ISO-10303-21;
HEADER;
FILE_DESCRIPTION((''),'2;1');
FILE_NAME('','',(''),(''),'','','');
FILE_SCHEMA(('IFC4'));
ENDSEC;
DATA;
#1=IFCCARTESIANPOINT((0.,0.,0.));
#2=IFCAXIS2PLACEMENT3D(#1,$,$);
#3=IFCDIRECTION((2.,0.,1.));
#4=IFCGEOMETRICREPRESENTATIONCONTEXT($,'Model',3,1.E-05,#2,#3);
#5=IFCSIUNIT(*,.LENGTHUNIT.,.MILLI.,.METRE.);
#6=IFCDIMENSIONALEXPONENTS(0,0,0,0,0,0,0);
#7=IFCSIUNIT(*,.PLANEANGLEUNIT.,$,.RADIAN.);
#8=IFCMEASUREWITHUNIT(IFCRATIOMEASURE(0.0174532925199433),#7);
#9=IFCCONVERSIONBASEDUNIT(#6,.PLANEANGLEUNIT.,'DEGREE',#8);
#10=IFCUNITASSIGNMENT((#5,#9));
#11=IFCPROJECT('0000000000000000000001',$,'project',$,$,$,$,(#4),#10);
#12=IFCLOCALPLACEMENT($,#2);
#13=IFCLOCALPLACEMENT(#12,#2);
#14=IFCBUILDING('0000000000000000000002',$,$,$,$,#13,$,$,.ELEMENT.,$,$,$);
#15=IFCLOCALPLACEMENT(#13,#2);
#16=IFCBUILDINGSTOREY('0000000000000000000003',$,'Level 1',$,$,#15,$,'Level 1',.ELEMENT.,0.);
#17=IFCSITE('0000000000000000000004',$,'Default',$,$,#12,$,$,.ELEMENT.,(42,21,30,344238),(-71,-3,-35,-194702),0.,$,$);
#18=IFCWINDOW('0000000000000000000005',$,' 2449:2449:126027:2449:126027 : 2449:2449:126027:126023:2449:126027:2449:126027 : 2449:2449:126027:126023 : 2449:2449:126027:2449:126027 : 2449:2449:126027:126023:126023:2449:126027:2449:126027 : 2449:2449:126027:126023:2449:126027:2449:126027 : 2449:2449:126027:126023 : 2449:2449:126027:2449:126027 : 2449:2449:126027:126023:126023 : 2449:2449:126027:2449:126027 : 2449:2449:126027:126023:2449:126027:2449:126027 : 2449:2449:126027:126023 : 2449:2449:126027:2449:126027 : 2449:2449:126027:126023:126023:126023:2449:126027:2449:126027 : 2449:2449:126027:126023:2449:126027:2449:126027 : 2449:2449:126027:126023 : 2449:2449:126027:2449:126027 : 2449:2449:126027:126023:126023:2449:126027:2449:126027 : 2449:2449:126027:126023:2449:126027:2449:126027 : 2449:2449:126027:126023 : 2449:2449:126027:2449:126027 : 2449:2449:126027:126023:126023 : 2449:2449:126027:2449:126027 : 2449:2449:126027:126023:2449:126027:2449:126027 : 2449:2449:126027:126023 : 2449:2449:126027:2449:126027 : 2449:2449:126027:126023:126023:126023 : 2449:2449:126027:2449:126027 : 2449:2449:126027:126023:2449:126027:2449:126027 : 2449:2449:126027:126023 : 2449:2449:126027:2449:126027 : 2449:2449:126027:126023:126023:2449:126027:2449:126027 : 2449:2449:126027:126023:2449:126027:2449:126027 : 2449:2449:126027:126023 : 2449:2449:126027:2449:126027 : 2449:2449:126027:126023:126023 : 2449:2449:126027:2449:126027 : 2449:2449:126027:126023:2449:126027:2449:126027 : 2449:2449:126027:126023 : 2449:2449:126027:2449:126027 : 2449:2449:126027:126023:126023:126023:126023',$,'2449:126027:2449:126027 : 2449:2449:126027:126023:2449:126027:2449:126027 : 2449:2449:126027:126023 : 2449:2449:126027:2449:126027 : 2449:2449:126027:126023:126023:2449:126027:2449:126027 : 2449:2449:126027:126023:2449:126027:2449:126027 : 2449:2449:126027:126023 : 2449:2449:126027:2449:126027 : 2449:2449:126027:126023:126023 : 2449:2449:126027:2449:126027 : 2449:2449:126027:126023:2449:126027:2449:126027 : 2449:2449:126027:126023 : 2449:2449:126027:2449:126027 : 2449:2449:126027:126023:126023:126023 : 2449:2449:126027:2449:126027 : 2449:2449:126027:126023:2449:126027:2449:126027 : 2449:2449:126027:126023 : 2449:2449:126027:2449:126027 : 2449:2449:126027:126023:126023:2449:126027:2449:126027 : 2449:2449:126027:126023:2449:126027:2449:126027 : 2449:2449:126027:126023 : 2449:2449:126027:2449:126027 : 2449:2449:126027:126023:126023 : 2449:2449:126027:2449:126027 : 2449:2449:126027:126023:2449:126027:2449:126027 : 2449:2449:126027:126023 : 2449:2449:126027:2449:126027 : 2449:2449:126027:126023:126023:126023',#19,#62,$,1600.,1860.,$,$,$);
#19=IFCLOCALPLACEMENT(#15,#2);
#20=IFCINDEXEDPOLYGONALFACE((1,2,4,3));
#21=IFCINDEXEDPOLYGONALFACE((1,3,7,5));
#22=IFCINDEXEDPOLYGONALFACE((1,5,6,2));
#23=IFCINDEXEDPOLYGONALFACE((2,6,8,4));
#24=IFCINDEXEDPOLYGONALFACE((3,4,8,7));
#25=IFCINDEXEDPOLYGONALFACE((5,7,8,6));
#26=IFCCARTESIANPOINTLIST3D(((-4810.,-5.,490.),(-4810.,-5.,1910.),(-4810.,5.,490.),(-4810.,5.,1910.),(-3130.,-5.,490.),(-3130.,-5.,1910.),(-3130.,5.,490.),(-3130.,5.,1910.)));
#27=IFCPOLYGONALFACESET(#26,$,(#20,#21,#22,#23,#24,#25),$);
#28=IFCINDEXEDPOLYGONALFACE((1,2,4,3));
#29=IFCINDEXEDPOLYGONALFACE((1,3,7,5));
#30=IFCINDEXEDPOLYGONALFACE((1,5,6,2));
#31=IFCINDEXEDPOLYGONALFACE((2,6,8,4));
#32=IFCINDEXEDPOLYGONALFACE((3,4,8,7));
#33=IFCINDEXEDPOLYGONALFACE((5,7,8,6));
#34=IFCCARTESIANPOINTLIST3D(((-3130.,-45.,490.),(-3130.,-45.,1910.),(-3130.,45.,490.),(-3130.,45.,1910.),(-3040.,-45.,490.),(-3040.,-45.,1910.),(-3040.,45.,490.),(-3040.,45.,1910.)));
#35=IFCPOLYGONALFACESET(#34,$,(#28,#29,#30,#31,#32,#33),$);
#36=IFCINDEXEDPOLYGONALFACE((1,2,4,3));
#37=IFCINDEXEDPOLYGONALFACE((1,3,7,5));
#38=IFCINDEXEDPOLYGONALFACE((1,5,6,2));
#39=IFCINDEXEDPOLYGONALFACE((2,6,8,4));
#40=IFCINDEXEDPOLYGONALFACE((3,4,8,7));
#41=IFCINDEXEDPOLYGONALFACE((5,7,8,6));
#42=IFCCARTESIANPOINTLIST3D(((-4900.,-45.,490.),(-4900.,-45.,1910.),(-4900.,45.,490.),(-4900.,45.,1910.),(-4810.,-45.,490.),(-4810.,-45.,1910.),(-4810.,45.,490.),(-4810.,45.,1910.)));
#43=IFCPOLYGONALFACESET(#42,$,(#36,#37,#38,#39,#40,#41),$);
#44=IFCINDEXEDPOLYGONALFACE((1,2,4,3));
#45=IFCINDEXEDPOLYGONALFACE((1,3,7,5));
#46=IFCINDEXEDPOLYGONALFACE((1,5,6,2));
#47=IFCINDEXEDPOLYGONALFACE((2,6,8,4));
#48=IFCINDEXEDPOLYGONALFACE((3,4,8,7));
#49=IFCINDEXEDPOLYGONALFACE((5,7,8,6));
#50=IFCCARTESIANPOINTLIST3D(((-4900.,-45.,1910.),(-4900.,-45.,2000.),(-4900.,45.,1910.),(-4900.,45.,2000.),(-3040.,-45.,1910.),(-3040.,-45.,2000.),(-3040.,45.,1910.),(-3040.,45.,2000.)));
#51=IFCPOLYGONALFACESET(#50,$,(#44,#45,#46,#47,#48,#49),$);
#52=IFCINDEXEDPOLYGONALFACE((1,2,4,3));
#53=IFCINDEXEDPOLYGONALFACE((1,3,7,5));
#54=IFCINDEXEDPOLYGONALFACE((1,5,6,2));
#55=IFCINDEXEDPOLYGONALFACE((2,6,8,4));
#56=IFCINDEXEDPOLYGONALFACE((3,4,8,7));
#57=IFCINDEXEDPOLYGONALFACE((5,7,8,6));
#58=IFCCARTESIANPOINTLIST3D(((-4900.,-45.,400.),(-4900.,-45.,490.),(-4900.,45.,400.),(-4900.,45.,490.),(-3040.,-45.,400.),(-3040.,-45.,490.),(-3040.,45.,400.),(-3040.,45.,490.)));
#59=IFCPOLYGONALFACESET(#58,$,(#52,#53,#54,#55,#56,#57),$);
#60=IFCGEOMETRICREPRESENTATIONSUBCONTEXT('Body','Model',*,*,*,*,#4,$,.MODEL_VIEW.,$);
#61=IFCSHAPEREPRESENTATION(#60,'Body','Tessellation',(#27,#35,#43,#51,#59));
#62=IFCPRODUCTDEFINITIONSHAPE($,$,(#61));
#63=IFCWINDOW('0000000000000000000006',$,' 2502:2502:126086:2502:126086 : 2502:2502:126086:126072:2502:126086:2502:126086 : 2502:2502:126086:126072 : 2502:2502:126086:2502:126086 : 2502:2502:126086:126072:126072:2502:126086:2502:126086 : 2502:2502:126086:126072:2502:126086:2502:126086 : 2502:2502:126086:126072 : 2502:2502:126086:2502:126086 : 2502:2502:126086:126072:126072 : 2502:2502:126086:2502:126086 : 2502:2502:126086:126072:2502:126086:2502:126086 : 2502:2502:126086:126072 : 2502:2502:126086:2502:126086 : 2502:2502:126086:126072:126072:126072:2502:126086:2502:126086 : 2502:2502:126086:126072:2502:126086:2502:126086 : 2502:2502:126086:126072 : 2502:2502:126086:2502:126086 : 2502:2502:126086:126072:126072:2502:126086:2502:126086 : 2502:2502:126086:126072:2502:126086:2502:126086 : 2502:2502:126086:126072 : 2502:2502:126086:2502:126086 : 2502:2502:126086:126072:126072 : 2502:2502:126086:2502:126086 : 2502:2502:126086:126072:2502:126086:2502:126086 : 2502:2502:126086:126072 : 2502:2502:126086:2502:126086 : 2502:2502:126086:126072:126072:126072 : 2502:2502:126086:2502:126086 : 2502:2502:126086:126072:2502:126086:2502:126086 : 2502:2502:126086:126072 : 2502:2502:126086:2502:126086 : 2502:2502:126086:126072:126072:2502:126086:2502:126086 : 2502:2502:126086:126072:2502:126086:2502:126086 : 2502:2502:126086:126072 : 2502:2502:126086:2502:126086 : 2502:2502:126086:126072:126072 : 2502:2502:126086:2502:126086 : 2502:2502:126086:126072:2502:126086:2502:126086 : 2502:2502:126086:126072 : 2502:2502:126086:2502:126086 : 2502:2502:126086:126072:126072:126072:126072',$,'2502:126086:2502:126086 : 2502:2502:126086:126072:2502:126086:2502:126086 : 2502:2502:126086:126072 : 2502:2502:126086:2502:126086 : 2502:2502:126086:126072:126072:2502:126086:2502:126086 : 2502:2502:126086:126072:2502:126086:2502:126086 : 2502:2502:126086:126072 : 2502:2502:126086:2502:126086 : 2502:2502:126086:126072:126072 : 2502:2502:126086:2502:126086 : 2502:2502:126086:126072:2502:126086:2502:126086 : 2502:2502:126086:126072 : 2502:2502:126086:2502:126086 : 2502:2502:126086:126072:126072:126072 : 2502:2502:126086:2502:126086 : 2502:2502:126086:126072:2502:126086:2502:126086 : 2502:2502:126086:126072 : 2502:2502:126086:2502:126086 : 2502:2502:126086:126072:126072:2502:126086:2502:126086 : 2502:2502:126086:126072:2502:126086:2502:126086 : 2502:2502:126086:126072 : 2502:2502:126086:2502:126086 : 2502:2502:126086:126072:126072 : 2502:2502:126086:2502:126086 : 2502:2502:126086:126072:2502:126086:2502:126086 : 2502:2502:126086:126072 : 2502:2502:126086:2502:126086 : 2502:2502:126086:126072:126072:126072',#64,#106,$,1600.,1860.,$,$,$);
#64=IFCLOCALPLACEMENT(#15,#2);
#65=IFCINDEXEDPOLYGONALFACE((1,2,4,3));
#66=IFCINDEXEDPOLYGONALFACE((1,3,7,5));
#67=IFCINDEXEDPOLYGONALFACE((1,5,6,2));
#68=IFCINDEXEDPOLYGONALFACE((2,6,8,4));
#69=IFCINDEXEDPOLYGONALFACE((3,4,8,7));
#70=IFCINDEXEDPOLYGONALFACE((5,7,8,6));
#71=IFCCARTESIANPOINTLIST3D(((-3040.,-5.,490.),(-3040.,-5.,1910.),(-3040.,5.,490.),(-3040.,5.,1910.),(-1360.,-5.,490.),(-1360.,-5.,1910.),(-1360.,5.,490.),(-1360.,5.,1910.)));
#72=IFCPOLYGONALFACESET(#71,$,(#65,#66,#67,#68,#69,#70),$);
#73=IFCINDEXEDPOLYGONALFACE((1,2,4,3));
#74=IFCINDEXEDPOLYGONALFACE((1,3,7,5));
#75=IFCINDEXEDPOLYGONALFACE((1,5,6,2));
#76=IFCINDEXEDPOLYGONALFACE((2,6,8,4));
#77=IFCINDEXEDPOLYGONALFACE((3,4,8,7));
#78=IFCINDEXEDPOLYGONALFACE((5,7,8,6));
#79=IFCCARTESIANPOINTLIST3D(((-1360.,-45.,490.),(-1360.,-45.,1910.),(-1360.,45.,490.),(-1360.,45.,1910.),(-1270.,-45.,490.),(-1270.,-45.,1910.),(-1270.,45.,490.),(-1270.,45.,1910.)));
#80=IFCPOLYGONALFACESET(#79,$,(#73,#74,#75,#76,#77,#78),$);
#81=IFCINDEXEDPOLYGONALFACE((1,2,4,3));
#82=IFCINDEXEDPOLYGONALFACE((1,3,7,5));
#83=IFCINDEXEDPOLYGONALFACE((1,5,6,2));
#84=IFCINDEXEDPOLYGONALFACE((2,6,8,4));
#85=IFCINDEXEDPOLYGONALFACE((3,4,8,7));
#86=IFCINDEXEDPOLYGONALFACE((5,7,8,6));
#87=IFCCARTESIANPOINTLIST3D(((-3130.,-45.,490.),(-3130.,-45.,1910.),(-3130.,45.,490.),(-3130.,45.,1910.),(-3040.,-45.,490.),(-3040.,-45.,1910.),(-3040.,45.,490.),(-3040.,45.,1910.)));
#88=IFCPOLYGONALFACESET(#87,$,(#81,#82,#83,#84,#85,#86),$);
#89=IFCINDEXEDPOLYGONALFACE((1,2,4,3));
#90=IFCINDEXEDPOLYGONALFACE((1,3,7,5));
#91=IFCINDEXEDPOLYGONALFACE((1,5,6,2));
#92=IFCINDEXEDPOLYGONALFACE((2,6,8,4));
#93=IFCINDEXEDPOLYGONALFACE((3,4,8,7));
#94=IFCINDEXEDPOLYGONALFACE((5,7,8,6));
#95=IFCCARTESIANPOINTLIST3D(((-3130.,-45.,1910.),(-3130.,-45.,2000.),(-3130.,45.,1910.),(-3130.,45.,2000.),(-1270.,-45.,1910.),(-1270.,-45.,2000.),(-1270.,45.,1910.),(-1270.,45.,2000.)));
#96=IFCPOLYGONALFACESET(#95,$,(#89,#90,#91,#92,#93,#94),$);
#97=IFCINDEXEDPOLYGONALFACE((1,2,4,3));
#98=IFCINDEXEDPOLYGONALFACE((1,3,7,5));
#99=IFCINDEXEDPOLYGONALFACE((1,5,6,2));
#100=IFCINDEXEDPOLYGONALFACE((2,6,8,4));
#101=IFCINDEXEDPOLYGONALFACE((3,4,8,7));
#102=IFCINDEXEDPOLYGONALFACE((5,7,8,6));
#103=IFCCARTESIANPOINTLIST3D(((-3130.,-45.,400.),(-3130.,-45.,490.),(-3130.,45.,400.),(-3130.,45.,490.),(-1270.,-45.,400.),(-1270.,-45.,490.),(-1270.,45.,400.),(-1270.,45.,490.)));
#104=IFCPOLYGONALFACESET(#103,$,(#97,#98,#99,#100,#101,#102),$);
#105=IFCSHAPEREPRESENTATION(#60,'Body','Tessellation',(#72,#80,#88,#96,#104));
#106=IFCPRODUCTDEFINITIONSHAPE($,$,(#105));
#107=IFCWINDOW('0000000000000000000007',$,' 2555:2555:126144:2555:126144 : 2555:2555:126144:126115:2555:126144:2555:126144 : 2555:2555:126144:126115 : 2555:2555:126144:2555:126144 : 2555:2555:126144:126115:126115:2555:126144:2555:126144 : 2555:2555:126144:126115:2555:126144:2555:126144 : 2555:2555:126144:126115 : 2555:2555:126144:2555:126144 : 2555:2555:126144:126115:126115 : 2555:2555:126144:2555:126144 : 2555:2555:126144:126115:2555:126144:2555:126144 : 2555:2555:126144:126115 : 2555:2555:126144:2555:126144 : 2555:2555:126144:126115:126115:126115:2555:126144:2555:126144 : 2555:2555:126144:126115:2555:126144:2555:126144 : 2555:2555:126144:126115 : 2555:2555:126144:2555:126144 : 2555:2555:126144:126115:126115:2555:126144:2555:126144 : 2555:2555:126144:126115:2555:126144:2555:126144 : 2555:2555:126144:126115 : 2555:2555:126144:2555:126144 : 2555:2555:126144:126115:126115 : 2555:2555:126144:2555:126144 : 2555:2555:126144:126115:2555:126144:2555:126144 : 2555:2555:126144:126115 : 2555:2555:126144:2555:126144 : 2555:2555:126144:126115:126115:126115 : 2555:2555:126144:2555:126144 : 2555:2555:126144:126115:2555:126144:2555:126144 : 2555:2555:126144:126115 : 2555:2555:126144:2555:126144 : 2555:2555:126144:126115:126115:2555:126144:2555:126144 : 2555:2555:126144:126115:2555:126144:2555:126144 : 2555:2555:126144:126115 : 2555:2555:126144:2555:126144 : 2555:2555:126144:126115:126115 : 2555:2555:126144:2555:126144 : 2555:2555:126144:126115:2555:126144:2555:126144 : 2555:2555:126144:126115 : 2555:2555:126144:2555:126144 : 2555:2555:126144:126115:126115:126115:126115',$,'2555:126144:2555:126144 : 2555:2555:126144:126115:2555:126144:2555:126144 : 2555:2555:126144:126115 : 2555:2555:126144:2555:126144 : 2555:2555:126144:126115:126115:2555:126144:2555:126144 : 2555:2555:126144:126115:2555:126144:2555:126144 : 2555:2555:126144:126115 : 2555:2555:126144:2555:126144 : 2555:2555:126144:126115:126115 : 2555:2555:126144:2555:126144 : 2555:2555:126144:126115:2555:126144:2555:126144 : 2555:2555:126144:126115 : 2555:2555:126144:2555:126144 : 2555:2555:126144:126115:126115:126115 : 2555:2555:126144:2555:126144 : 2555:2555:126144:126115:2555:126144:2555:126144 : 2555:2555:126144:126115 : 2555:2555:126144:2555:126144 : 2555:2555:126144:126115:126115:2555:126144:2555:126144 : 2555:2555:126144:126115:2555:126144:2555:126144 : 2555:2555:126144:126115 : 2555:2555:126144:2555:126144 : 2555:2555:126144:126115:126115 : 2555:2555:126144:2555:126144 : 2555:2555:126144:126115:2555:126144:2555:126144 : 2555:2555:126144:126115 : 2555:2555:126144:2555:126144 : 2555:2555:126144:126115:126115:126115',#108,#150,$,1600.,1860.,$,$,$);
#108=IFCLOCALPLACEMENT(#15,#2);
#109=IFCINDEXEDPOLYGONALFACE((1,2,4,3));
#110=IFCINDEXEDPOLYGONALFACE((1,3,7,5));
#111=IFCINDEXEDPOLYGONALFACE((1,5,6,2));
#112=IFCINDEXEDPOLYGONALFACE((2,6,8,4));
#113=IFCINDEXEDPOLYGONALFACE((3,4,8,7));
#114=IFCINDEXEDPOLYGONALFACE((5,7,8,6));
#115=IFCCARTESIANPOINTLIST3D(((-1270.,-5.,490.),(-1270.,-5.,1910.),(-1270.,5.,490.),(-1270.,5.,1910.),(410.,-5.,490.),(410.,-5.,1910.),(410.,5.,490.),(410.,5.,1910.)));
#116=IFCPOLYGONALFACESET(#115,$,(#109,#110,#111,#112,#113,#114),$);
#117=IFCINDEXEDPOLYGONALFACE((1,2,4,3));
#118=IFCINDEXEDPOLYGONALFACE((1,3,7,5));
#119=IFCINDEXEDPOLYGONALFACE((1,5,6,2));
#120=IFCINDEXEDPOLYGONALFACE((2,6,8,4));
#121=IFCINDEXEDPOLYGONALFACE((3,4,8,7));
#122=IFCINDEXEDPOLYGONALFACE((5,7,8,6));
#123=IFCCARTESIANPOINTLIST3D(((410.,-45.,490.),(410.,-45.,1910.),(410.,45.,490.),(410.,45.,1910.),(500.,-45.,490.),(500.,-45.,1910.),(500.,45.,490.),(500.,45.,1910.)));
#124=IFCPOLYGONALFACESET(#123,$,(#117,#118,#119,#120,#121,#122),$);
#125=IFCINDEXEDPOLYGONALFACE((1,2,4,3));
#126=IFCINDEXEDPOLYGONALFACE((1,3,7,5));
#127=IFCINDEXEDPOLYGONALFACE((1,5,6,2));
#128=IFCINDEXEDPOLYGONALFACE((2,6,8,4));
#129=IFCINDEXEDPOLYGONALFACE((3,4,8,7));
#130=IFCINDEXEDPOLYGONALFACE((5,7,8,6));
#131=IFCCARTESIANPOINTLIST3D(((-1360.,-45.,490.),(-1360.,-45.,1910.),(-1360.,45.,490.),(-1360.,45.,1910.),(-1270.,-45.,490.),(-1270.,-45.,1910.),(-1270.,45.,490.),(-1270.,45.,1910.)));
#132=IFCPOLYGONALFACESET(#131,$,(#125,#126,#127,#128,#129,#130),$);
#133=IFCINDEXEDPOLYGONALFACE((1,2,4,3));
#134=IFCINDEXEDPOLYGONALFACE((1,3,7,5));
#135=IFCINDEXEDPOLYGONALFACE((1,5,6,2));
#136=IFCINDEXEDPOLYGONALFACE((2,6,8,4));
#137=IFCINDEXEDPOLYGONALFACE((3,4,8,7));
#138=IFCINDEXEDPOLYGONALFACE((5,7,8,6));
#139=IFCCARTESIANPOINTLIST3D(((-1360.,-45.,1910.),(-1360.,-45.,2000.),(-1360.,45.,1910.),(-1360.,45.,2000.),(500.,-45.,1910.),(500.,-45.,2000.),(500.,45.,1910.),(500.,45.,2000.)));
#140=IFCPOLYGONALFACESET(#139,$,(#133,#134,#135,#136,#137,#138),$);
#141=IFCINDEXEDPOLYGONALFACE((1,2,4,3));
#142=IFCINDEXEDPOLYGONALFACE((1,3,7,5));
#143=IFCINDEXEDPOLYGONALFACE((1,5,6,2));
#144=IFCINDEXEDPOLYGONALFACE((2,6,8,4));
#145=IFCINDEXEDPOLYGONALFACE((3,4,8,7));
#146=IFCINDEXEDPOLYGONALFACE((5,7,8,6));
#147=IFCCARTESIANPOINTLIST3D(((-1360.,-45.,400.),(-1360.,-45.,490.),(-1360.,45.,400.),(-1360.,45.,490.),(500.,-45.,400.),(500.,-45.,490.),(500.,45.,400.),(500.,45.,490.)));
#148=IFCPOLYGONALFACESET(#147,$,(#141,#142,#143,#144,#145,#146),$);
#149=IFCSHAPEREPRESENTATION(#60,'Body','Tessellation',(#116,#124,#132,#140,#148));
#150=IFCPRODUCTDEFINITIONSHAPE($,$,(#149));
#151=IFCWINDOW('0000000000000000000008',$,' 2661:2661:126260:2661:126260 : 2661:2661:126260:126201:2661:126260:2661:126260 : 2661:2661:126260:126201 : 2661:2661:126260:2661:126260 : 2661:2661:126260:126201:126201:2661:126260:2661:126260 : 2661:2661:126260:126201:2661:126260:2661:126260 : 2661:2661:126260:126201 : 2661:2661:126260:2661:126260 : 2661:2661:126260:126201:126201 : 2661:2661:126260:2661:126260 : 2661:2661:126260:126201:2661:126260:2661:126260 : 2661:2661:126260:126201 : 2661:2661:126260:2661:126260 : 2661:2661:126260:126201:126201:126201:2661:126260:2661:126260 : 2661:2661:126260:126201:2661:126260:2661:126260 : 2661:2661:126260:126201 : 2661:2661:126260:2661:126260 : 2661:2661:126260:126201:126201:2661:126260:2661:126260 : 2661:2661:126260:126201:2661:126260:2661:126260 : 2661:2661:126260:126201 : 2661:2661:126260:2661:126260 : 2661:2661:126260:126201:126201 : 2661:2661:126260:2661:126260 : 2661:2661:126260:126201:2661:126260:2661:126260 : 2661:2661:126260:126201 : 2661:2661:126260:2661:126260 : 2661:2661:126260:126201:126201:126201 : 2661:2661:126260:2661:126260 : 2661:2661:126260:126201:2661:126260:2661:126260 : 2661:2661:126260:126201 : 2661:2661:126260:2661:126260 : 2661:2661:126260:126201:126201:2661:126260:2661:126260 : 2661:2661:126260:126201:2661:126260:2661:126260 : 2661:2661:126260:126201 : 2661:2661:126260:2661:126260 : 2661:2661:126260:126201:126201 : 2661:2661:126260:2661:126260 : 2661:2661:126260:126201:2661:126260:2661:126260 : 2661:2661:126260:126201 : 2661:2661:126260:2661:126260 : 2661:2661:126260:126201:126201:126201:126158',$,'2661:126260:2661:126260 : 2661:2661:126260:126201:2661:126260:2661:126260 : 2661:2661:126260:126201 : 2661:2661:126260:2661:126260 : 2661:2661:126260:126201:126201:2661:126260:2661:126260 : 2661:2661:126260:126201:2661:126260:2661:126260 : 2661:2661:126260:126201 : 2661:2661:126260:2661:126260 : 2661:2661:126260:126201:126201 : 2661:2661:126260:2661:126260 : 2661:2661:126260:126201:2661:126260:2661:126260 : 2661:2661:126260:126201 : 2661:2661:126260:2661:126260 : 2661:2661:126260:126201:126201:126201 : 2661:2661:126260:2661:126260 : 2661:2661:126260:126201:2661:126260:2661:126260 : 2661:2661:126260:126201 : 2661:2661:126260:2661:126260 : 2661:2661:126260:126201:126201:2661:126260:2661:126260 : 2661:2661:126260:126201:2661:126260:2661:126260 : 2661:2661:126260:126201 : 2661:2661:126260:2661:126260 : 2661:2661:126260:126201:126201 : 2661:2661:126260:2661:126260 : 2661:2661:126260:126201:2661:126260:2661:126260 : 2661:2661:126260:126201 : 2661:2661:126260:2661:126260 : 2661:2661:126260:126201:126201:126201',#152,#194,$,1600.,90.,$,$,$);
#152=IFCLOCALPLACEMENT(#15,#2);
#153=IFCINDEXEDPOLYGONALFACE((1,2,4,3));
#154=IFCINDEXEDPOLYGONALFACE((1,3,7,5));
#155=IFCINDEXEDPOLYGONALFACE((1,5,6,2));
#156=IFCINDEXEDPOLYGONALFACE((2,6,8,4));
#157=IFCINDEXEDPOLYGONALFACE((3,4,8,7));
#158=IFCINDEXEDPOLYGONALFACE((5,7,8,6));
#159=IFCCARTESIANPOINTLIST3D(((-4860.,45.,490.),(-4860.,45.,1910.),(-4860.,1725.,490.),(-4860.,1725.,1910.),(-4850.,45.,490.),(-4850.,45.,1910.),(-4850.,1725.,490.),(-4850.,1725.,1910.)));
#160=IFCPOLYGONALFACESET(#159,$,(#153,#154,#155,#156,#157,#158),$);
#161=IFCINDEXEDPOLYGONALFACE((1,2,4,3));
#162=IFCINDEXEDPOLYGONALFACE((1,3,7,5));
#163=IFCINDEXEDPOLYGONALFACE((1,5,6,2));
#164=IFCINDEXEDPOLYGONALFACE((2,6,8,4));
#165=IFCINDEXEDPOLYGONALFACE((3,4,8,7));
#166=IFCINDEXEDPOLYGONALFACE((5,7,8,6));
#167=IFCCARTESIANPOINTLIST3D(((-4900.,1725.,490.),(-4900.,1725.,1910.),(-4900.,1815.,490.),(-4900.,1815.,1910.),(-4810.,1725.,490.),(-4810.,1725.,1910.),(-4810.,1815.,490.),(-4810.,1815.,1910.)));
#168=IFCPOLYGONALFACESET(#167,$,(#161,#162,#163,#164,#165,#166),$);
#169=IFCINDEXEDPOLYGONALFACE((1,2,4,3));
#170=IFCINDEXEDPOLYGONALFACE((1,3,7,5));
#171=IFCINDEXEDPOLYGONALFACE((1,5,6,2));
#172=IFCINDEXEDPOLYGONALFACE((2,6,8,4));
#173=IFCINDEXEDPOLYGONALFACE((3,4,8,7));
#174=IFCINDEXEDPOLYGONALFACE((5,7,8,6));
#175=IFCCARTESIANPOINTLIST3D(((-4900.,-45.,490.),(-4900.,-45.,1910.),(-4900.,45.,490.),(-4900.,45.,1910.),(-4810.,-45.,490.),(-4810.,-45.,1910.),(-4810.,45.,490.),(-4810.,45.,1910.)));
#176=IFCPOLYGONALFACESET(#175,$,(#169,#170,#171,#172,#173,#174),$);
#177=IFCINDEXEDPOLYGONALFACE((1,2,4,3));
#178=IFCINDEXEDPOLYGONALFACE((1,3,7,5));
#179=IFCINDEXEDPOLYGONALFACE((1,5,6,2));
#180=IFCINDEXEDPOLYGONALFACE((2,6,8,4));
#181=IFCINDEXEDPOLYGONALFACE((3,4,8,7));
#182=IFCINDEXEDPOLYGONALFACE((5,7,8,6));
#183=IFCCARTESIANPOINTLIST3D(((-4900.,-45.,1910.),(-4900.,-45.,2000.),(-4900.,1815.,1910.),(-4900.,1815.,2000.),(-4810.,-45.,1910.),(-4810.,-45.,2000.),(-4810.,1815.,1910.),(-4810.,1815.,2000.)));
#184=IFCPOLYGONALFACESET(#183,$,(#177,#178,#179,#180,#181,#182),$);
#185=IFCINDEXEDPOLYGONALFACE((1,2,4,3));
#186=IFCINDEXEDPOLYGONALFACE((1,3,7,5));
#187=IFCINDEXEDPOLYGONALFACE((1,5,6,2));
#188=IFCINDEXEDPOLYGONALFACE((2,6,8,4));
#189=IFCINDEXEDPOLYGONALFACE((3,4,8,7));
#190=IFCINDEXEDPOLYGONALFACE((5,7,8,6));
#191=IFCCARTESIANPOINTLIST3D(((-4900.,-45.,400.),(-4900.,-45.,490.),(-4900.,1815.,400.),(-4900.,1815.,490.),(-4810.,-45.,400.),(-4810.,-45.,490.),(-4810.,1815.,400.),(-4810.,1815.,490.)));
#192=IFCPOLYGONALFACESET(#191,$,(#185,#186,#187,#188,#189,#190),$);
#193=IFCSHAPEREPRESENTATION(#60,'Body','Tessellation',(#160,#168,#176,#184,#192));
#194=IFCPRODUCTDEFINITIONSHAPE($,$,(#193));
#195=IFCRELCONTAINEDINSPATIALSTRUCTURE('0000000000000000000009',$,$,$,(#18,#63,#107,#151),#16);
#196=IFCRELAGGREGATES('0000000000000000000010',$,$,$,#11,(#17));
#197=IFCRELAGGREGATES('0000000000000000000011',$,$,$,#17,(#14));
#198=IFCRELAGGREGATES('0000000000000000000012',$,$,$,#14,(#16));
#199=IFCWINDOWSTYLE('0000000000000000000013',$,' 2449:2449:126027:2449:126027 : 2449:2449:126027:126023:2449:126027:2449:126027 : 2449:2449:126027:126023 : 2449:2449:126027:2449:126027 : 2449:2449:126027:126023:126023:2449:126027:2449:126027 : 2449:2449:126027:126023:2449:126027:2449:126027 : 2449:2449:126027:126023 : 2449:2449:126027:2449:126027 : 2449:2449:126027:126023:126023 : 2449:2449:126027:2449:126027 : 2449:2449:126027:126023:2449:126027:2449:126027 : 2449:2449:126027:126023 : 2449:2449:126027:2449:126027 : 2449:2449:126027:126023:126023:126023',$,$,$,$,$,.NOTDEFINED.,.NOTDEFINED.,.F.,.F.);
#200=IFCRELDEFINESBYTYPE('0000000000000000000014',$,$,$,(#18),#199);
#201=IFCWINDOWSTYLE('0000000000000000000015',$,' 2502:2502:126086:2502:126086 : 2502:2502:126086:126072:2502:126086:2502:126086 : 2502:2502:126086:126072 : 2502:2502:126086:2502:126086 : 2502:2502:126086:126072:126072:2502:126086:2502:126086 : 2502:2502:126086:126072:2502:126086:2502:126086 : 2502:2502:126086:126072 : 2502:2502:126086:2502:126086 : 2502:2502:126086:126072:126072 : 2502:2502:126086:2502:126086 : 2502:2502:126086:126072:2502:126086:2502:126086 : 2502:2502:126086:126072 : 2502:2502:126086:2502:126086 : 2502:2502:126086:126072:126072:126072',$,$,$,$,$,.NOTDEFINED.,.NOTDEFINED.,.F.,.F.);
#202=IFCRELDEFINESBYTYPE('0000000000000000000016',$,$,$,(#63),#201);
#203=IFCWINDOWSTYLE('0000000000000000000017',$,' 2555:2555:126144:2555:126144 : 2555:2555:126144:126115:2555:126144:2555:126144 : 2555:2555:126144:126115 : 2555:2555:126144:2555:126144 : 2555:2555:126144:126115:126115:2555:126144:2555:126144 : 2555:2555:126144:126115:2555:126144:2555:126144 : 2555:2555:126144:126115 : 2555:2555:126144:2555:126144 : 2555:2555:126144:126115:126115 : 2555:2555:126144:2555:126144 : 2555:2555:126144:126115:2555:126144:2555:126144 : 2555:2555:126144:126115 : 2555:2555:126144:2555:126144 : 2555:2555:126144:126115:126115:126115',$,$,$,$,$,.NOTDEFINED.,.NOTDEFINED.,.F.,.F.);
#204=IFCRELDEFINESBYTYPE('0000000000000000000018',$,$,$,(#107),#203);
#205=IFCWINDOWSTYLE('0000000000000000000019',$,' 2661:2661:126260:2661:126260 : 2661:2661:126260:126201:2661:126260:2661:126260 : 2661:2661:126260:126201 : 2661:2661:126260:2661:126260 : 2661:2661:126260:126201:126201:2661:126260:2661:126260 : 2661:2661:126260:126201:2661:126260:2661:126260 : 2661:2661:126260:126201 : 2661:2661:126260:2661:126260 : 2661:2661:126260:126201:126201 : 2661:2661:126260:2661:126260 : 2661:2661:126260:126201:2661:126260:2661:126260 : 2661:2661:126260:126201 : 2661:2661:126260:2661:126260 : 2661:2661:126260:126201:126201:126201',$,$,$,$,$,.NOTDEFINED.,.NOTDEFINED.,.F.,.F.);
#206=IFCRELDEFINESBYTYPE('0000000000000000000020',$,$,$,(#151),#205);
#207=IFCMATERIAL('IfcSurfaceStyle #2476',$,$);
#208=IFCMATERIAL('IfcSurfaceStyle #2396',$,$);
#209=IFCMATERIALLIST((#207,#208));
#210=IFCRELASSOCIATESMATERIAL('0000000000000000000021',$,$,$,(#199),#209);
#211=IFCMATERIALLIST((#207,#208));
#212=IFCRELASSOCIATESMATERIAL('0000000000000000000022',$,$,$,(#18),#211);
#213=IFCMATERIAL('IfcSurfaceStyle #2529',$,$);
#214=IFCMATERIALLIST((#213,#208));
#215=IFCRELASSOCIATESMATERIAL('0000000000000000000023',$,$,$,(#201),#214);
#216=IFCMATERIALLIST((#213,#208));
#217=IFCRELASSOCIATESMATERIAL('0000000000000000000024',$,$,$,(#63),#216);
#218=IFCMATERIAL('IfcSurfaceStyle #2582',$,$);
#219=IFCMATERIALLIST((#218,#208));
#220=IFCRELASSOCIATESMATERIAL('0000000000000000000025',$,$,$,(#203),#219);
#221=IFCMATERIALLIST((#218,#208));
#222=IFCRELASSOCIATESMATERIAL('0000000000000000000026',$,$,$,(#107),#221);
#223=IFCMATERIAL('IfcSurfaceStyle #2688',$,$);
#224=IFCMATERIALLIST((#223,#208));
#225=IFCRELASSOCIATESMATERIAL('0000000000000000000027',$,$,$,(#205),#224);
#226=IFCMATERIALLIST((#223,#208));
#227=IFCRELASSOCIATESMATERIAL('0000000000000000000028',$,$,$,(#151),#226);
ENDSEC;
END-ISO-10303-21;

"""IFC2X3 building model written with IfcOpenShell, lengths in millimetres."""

from ifc_helpers import new_model, entity, si_unit, converted_unit, direction, frame, frame_2d, origin, origin_2d_with_axis, place, context, subcontext, project, spatial, rectangle, extrude, source, transform, mapped, material, material_list, type_object, type_shapes, element, save


model = new_model("IFC2X3")

# Units and contexts
model_context = context("Model", 3, precision=1e-05, world=origin(), true_north=direction((2.0, 0.0, 1.0)))
body_context = subcontext(model_context, "Body", "Model", "MODEL_VIEW")
ifc_project = project(units=[si_unit("LENGTHUNIT", "METRE", prefix="MILLI"), converted_unit("PLANEANGLEUNIT", "DEGREE", entity("IfcRatioMeasure", 0.0174532925199433), si_unit("PLANEANGLEUNIT", "RADIAN"), dimensions=[0, 0, 0, 0, 0, 0, 0])], contexts=[model_context])

# Site, building, storey
site_placement = place(None, origin())
site = spatial("IfcSite", under=ifc_project, at=site_placement, Name="Default", CompositionType="ELEMENT", RefLatitude=(42, 21, 30, 344238), RefLongitude=(-71, -3, -35, -194702), RefElevation=0.0)
building_placement = place(site_placement, origin())
building = spatial("IfcBuilding", under=site, at=building_placement, CompositionType="ELEMENT")
storey_placement = place(building_placement, origin())
storey = spatial("IfcBuildingStorey", under=building, at=storey_placement, Name="Level 1", LongName="Level 1", CompositionType="ELEMENT", Elevation=0.0)

# Windows
ifc_material_1 = material(Name="IfcSurfaceStyle #2476")
ifc_material_2 = material(Name="IfcSurfaceStyle #2396")
ifc_material_list_1 = material_list([ifc_material_1, ifc_material_2])
ifc_material_list_2 = material_list([ifc_material_1, ifc_material_2])
window_style_1 = type_object("IfcWindowStyle", Name=" 2449:2449:126027:2449:126027 : 2449:2449:126027:126023:2449:126027:2449:126027 : 2449:2449:126027:126023 : 2449:2449:126027:2449:126027 : 2449:2449:126027:126023:126023:2449:126027:2449:126027 : 2449:2449:126027:126023:2449:126027:2449:126027 : 2449:2449:126027:126023 : 2449:2449:126027:2449:126027 : 2449:2449:126027:126023:126023 : 2449:2449:126027:2449:126027 : 2449:2449:126027:126023:2449:126027:2449:126027 : 2449:2449:126027:126023 : 2449:2449:126027:2449:126027 : 2449:2449:126027:126023:126023:126023", ConstructionType="NOTDEFINED", OperationType="NOTDEFINED", ParameterTakesPrecedence=False, Sizeable=False, material=ifc_material_list_2)
shared_shape_1 = source(origin(), body_context, "Body", "SweptSolid", [
    extrude(rectangle(XDim=10.0, YDim=1680.0, at=origin_2d_with_axis()), frame((-3970.0, 0.0, 490.0), z_axis=(0.0, 0.0, 1.0), x_axis=(0.0, 1.0, 0.0)), (0.0, 0.0, 1.0), 1420.0),
    extrude(rectangle(XDim=90.0, YDim=90.0, at=frame_2d((0.0, 0.0), x_axis=(1.0, 0.0))), frame((-3085.0, 0.0, 490.0), z_axis=(0.0, 0.0, 1.0), x_axis=(0.0, 1.0, 0.0)), (0.0, 0.0, 1.0), 1420.0),
    extrude(rectangle(XDim=90.0, YDim=90.0, at=frame_2d((0.0, 0.0), x_axis=(1.0, 0.0))), frame((-4855.0, 0.0, 490.0), z_axis=(0.0, 0.0, 1.0), x_axis=(0.0, 1.0, 0.0)), (0.0, 0.0, 1.0), 1420.0),
    extrude(rectangle(XDim=90.0, YDim=1860.0, at=frame_2d((0.0, 0.0), x_axis=(1.0, 0.0))), frame((-3970.0, 0.0, 1910.0), z_axis=(0.0, 0.0, 1.0), x_axis=(0.0, 1.0, 0.0)), (0.0, 0.0, 1.0), 90.0),
    extrude(rectangle(XDim=90.0, YDim=1860.0, at=frame_2d((0.0, 0.0), x_axis=(1.0, 0.0))), frame((-3970.0, 0.0, 400.0), z_axis=(0.0, 0.0, 1.0), x_axis=(0.0, 1.0, 0.0)), (0.0, 0.0, 1.0), 90.0),
])
type_shapes(window_style_1, [shared_shape_1])
window_1_placement = place(storey_placement, origin())
element("IfcWindow", 1, at=window_1_placement, inside=storey, type_object=window_style_1, material=ifc_material_list_1, Name=" 2449:2449:126027:2449:126027 : 2449:2449:126027:126023:2449:126027:2449:126027 : 2449:2449:126027:126023 : 2449:2449:126027:2449:126027 : 2449:2449:126027:126023:126023:2449:126027:2449:126027 : 2449:2449:126027:126023:2449:126027:2449:126027 : 2449:2449:126027:126023 : 2449:2449:126027:2449:126027 : 2449:2449:126027:126023:126023 : 2449:2449:126027:2449:126027 : 2449:2449:126027:126023:2449:126027:2449:126027 : 2449:2449:126027:126023 : 2449:2449:126027:2449:126027 : 2449:2449:126027:126023:126023:126023:2449:126027:2449:126027 : 2449:2449:126027:126023:2449:126027:2449:126027 : 2449:2449:126027:126023 : 2449:2449:126027:2449:126027 : 2449:2449:126027:126023:126023:2449:126027:2449:126027 : 2449:2449:126027:126023:2449:126027:2449:126027 : 2449:2449:126027:126023 : 2449:2449:126027:2449:126027 : 2449:2449:126027:126023:126023 : 2449:2449:126027:2449:126027 : 2449:2449:126027:126023:2449:126027:2449:126027 : 2449:2449:126027:126023 : 2449:2449:126027:2449:126027 : 2449:2449:126027:126023:126023:126023 : 2449:2449:126027:2449:126027 : 2449:2449:126027:126023:2449:126027:2449:126027 : 2449:2449:126027:126023 : 2449:2449:126027:2449:126027 : 2449:2449:126027:126023:126023:2449:126027:2449:126027 : 2449:2449:126027:126023:2449:126027:2449:126027 : 2449:2449:126027:126023 : 2449:2449:126027:2449:126027 : 2449:2449:126027:126023:126023 : 2449:2449:126027:2449:126027 : 2449:2449:126027:126023:2449:126027:2449:126027 : 2449:2449:126027:126023 : 2449:2449:126027:2449:126027 : 2449:2449:126027:126023:126023:126023:126023", ObjectType="2449:126027:2449:126027 : 2449:2449:126027:126023:2449:126027:2449:126027 : 2449:2449:126027:126023 : 2449:2449:126027:2449:126027 : 2449:2449:126027:126023:126023:2449:126027:2449:126027 : 2449:2449:126027:126023:2449:126027:2449:126027 : 2449:2449:126027:126023 : 2449:2449:126027:2449:126027 : 2449:2449:126027:126023:126023 : 2449:2449:126027:2449:126027 : 2449:2449:126027:126023:2449:126027:2449:126027 : 2449:2449:126027:126023 : 2449:2449:126027:2449:126027 : 2449:2449:126027:126023:126023:126023 : 2449:2449:126027:2449:126027 : 2449:2449:126027:126023:2449:126027:2449:126027 : 2449:2449:126027:126023 : 2449:2449:126027:2449:126027 : 2449:2449:126027:126023:126023:2449:126027:2449:126027 : 2449:2449:126027:126023:2449:126027:2449:126027 : 2449:2449:126027:126023 : 2449:2449:126027:2449:126027 : 2449:2449:126027:126023:126023 : 2449:2449:126027:2449:126027 : 2449:2449:126027:126023:2449:126027:2449:126027 : 2449:2449:126027:126023 : 2449:2449:126027:2449:126027 : 2449:2449:126027:126023:126023:126023", OverallHeight=1600.0, OverallWidth=1860.0, context=body_context, shape_type="MappedRepresentation", body=[
    mapped(shared_shape_1, transform((0.0, 0.0, 0.0), scale=1.0)),
])
ifc_material_3 = material(Name="IfcSurfaceStyle #2529")
ifc_material_list_3 = material_list([ifc_material_3, ifc_material_2])
ifc_material_list_4 = material_list([ifc_material_3, ifc_material_2])
window_style_2 = type_object("IfcWindowStyle", Name=" 2502:2502:126086:2502:126086 : 2502:2502:126086:126072:2502:126086:2502:126086 : 2502:2502:126086:126072 : 2502:2502:126086:2502:126086 : 2502:2502:126086:126072:126072:2502:126086:2502:126086 : 2502:2502:126086:126072:2502:126086:2502:126086 : 2502:2502:126086:126072 : 2502:2502:126086:2502:126086 : 2502:2502:126086:126072:126072 : 2502:2502:126086:2502:126086 : 2502:2502:126086:126072:2502:126086:2502:126086 : 2502:2502:126086:126072 : 2502:2502:126086:2502:126086 : 2502:2502:126086:126072:126072:126072", ConstructionType="NOTDEFINED", OperationType="NOTDEFINED", ParameterTakesPrecedence=False, Sizeable=False, material=ifc_material_list_4)
shared_shape_2 = source(origin(), body_context, "Body", "SweptSolid", [
    extrude(rectangle(XDim=10.0, YDim=1680.0, at=origin_2d_with_axis()), frame((-2200.0, 0.0, 490.0), z_axis=(0.0, 0.0, 1.0), x_axis=(0.0, 1.0, 0.0)), (0.0, 0.0, 1.0), 1420.0),
    extrude(rectangle(XDim=90.0, YDim=90.0, at=frame_2d((0.0, 0.0), x_axis=(1.0, 0.0))), frame((-1315.0, 0.0, 490.0), z_axis=(0.0, 0.0, 1.0), x_axis=(0.0, 1.0, 0.0)), (0.0, 0.0, 1.0), 1420.0),
    extrude(rectangle(XDim=90.0, YDim=90.0, at=frame_2d((0.0, 0.0), x_axis=(1.0, 0.0))), frame((-3085.0, 0.0, 490.0), z_axis=(0.0, 0.0, 1.0), x_axis=(0.0, 1.0, 0.0)), (0.0, 0.0, 1.0), 1420.0),
    extrude(rectangle(XDim=90.0, YDim=1860.0, at=frame_2d((0.0, 0.0), x_axis=(1.0, 0.0))), frame((-2200.0, 0.0, 1910.0), z_axis=(0.0, 0.0, 1.0), x_axis=(0.0, 1.0, 0.0)), (0.0, 0.0, 1.0), 90.0),
    extrude(rectangle(XDim=90.0, YDim=1860.0, at=frame_2d((0.0, 0.0), x_axis=(1.0, 0.0))), frame((-2200.0, 0.0, 400.0), z_axis=(0.0, 0.0, 1.0), x_axis=(0.0, 1.0, 0.0)), (0.0, 0.0, 1.0), 90.0),
])
type_shapes(window_style_2, [shared_shape_2])
window_2_placement = place(storey_placement, origin())
element("IfcWindow", 2, at=window_2_placement, inside=storey, type_object=window_style_2, material=ifc_material_list_3, Name=" 2502:2502:126086:2502:126086 : 2502:2502:126086:126072:2502:126086:2502:126086 : 2502:2502:126086:126072 : 2502:2502:126086:2502:126086 : 2502:2502:126086:126072:126072:2502:126086:2502:126086 : 2502:2502:126086:126072:2502:126086:2502:126086 : 2502:2502:126086:126072 : 2502:2502:126086:2502:126086 : 2502:2502:126086:126072:126072 : 2502:2502:126086:2502:126086 : 2502:2502:126086:126072:2502:126086:2502:126086 : 2502:2502:126086:126072 : 2502:2502:126086:2502:126086 : 2502:2502:126086:126072:126072:126072:2502:126086:2502:126086 : 2502:2502:126086:126072:2502:126086:2502:126086 : 2502:2502:126086:126072 : 2502:2502:126086:2502:126086 : 2502:2502:126086:126072:126072:2502:126086:2502:126086 : 2502:2502:126086:126072:2502:126086:2502:126086 : 2502:2502:126086:126072 : 2502:2502:126086:2502:126086 : 2502:2502:126086:126072:126072 : 2502:2502:126086:2502:126086 : 2502:2502:126086:126072:2502:126086:2502:126086 : 2502:2502:126086:126072 : 2502:2502:126086:2502:126086 : 2502:2502:126086:126072:126072:126072 : 2502:2502:126086:2502:126086 : 2502:2502:126086:126072:2502:126086:2502:126086 : 2502:2502:126086:126072 : 2502:2502:126086:2502:126086 : 2502:2502:126086:126072:126072:2502:126086:2502:126086 : 2502:2502:126086:126072:2502:126086:2502:126086 : 2502:2502:126086:126072 : 2502:2502:126086:2502:126086 : 2502:2502:126086:126072:126072 : 2502:2502:126086:2502:126086 : 2502:2502:126086:126072:2502:126086:2502:126086 : 2502:2502:126086:126072 : 2502:2502:126086:2502:126086 : 2502:2502:126086:126072:126072:126072:126072", ObjectType="2502:126086:2502:126086 : 2502:2502:126086:126072:2502:126086:2502:126086 : 2502:2502:126086:126072 : 2502:2502:126086:2502:126086 : 2502:2502:126086:126072:126072:2502:126086:2502:126086 : 2502:2502:126086:126072:2502:126086:2502:126086 : 2502:2502:126086:126072 : 2502:2502:126086:2502:126086 : 2502:2502:126086:126072:126072 : 2502:2502:126086:2502:126086 : 2502:2502:126086:126072:2502:126086:2502:126086 : 2502:2502:126086:126072 : 2502:2502:126086:2502:126086 : 2502:2502:126086:126072:126072:126072 : 2502:2502:126086:2502:126086 : 2502:2502:126086:126072:2502:126086:2502:126086 : 2502:2502:126086:126072 : 2502:2502:126086:2502:126086 : 2502:2502:126086:126072:126072:2502:126086:2502:126086 : 2502:2502:126086:126072:2502:126086:2502:126086 : 2502:2502:126086:126072 : 2502:2502:126086:2502:126086 : 2502:2502:126086:126072:126072 : 2502:2502:126086:2502:126086 : 2502:2502:126086:126072:2502:126086:2502:126086 : 2502:2502:126086:126072 : 2502:2502:126086:2502:126086 : 2502:2502:126086:126072:126072:126072", OverallHeight=1600.0, OverallWidth=1860.0, context=body_context, shape_type="MappedRepresentation", body=[
    mapped(shared_shape_2, transform((0.0, 0.0, 0.0), scale=1.0)),
])
ifc_material_4 = material(Name="IfcSurfaceStyle #2582")
ifc_material_list_5 = material_list([ifc_material_4, ifc_material_2])
ifc_material_list_6 = material_list([ifc_material_4, ifc_material_2])
window_style_3 = type_object("IfcWindowStyle", Name=" 2555:2555:126144:2555:126144 : 2555:2555:126144:126115:2555:126144:2555:126144 : 2555:2555:126144:126115 : 2555:2555:126144:2555:126144 : 2555:2555:126144:126115:126115:2555:126144:2555:126144 : 2555:2555:126144:126115:2555:126144:2555:126144 : 2555:2555:126144:126115 : 2555:2555:126144:2555:126144 : 2555:2555:126144:126115:126115 : 2555:2555:126144:2555:126144 : 2555:2555:126144:126115:2555:126144:2555:126144 : 2555:2555:126144:126115 : 2555:2555:126144:2555:126144 : 2555:2555:126144:126115:126115:126115", ConstructionType="NOTDEFINED", OperationType="NOTDEFINED", ParameterTakesPrecedence=False, Sizeable=False, material=ifc_material_list_6)
shared_shape_3 = source(origin(), body_context, "Body", "SweptSolid", [
    extrude(rectangle(XDim=10.0, YDim=1680.0, at=origin_2d_with_axis()), frame((-430.0, 0.0, 490.0), z_axis=(0.0, 0.0, 1.0), x_axis=(0.0, 1.0, 0.0)), (0.0, 0.0, 1.0), 1420.0),
    extrude(rectangle(XDim=90.0, YDim=90.0, at=origin_2d_with_axis()), frame((455.0, 0.0, 490.0), z_axis=(0.0, 0.0, 1.0), x_axis=(0.0, 1.0, 0.0)), (0.0, 0.0, 1.0), 1420.0),
    extrude(rectangle(XDim=90.0, YDim=90.0, at=frame_2d((0.0, 0.0), x_axis=(1.0, 0.0))), frame((-1315.0, 0.0, 490.0), z_axis=(0.0, 0.0, 1.0), x_axis=(0.0, 1.0, 0.0)), (0.0, 0.0, 1.0), 1420.0),
    extrude(rectangle(XDim=90.0, YDim=1860.0, at=origin_2d_with_axis()), frame((-430.0, 0.0, 1910.0), z_axis=(0.0, 0.0, 1.0), x_axis=(0.0, 1.0, 0.0)), (0.0, 0.0, 1.0), 90.0),
    extrude(rectangle(XDim=90.0, YDim=1860.0, at=origin_2d_with_axis()), frame((-430.0, 0.0, 400.0), z_axis=(0.0, 0.0, 1.0), x_axis=(0.0, 1.0, 0.0)), (0.0, 0.0, 1.0), 90.0),
])
type_shapes(window_style_3, [shared_shape_3])
window_3_placement = place(storey_placement, origin())
element("IfcWindow", 3, at=window_3_placement, inside=storey, type_object=window_style_3, material=ifc_material_list_5, Name=" 2555:2555:126144:2555:126144 : 2555:2555:126144:126115:2555:126144:2555:126144 : 2555:2555:126144:126115 : 2555:2555:126144:2555:126144 : 2555:2555:126144:126115:126115:2555:126144:2555:126144 : 2555:2555:126144:126115:2555:126144:2555:126144 : 2555:2555:126144:126115 : 2555:2555:126144:2555:126144 : 2555:2555:126144:126115:126115 : 2555:2555:126144:2555:126144 : 2555:2555:126144:126115:2555:126144:2555:126144 : 2555:2555:126144:126115 : 2555:2555:126144:2555:126144 : 2555:2555:126144:126115:126115:126115:2555:126144:2555:126144 : 2555:2555:126144:126115:2555:126144:2555:126144 : 2555:2555:126144:126115 : 2555:2555:126144:2555:126144 : 2555:2555:126144:126115:126115:2555:126144:2555:126144 : 2555:2555:126144:126115:2555:126144:2555:126144 : 2555:2555:126144:126115 : 2555:2555:126144:2555:126144 : 2555:2555:126144:126115:126115 : 2555:2555:126144:2555:126144 : 2555:2555:126144:126115:2555:126144:2555:126144 : 2555:2555:126144:126115 : 2555:2555:126144:2555:126144 : 2555:2555:126144:126115:126115:126115 : 2555:2555:126144:2555:126144 : 2555:2555:126144:126115:2555:126144:2555:126144 : 2555:2555:126144:126115 : 2555:2555:126144:2555:126144 : 2555:2555:126144:126115:126115:2555:126144:2555:126144 : 2555:2555:126144:126115:2555:126144:2555:126144 : 2555:2555:126144:126115 : 2555:2555:126144:2555:126144 : 2555:2555:126144:126115:126115 : 2555:2555:126144:2555:126144 : 2555:2555:126144:126115:2555:126144:2555:126144 : 2555:2555:126144:126115 : 2555:2555:126144:2555:126144 : 2555:2555:126144:126115:126115:126115:126115", ObjectType="2555:126144:2555:126144 : 2555:2555:126144:126115:2555:126144:2555:126144 : 2555:2555:126144:126115 : 2555:2555:126144:2555:126144 : 2555:2555:126144:126115:126115:2555:126144:2555:126144 : 2555:2555:126144:126115:2555:126144:2555:126144 : 2555:2555:126144:126115 : 2555:2555:126144:2555:126144 : 2555:2555:126144:126115:126115 : 2555:2555:126144:2555:126144 : 2555:2555:126144:126115:2555:126144:2555:126144 : 2555:2555:126144:126115 : 2555:2555:126144:2555:126144 : 2555:2555:126144:126115:126115:126115 : 2555:2555:126144:2555:126144 : 2555:2555:126144:126115:2555:126144:2555:126144 : 2555:2555:126144:126115 : 2555:2555:126144:2555:126144 : 2555:2555:126144:126115:126115:2555:126144:2555:126144 : 2555:2555:126144:126115:2555:126144:2555:126144 : 2555:2555:126144:126115 : 2555:2555:126144:2555:126144 : 2555:2555:126144:126115:126115 : 2555:2555:126144:2555:126144 : 2555:2555:126144:126115:2555:126144:2555:126144 : 2555:2555:126144:126115 : 2555:2555:126144:2555:126144 : 2555:2555:126144:126115:126115:126115", OverallHeight=1600.0, OverallWidth=1860.0, context=body_context, shape_type="MappedRepresentation", body=[
    mapped(shared_shape_3, transform((0.0, 0.0, 0.0), scale=1.0)),
])
ifc_material_5 = material(Name="IfcSurfaceStyle #2688")
ifc_material_list_7 = material_list([ifc_material_5, ifc_material_2])
ifc_material_list_8 = material_list([ifc_material_5, ifc_material_2])
window_style_4 = type_object("IfcWindowStyle", Name=" 2661:2661:126260:2661:126260 : 2661:2661:126260:126201:2661:126260:2661:126260 : 2661:2661:126260:126201 : 2661:2661:126260:2661:126260 : 2661:2661:126260:126201:126201:2661:126260:2661:126260 : 2661:2661:126260:126201:2661:126260:2661:126260 : 2661:2661:126260:126201 : 2661:2661:126260:2661:126260 : 2661:2661:126260:126201:126201 : 2661:2661:126260:2661:126260 : 2661:2661:126260:126201:2661:126260:2661:126260 : 2661:2661:126260:126201 : 2661:2661:126260:2661:126260 : 2661:2661:126260:126201:126201:126201", ConstructionType="NOTDEFINED", OperationType="NOTDEFINED", ParameterTakesPrecedence=False, Sizeable=False, material=ifc_material_list_8)
shared_shape_4 = source(origin(), body_context, "Body", "SweptSolid", [
    extrude(rectangle(XDim=10.0, YDim=1680.0, at=origin_2d_with_axis()), frame((-4855.0, 885.0, 490.0), z_axis=(0.0, 0.0, 1.0), x_axis=(-1.0, 0.0, 0.0)), (0.0, 0.0, 1.0), 1420.0),
    extrude(rectangle(XDim=90.0, YDim=90.0, at=frame_2d((0.0, 0.0), x_axis=(1.0, 0.0))), frame((-4855.0, 1770.0, 490.0), z_axis=(0.0, 0.0, 1.0), x_axis=(-1.0, 0.0, 0.0)), (0.0, 0.0, 1.0), 1420.0),
    extrude(rectangle(XDim=90.0, YDim=90.0, at=origin_2d_with_axis()), frame((-4855.0, 0.0, 490.0), z_axis=(0.0, 0.0, 1.0), x_axis=(-1.0, 0.0, 0.0)), (0.0, 0.0, 1.0), 1420.0),
    extrude(rectangle(XDim=90.0, YDim=1860.0, at=origin_2d_with_axis()), frame((-4855.0, 885.0, 1910.0), z_axis=(0.0, 0.0, 1.0), x_axis=(-1.0, 0.0, 0.0)), (0.0, 0.0, 1.0), 90.0),
    extrude(rectangle(XDim=90.0, YDim=1860.0, at=origin_2d_with_axis()), frame((-4855.0, 885.0, 400.0), z_axis=(0.0, 0.0, 1.0), x_axis=(-1.0, 0.0, 0.0)), (0.0, 0.0, 1.0), 90.0),
])
type_shapes(window_style_4, [shared_shape_4])
window_4_placement = place(storey_placement, origin())
element("IfcWindow", 4, at=window_4_placement, inside=storey, type_object=window_style_4, material=ifc_material_list_7, Name=" 2661:2661:126260:2661:126260 : 2661:2661:126260:126201:2661:126260:2661:126260 : 2661:2661:126260:126201 : 2661:2661:126260:2661:126260 : 2661:2661:126260:126201:126201:2661:126260:2661:126260 : 2661:2661:126260:126201:2661:126260:2661:126260 : 2661:2661:126260:126201 : 2661:2661:126260:2661:126260 : 2661:2661:126260:126201:126201 : 2661:2661:126260:2661:126260 : 2661:2661:126260:126201:2661:126260:2661:126260 : 2661:2661:126260:126201 : 2661:2661:126260:2661:126260 : 2661:2661:126260:126201:126201:126201:2661:126260:2661:126260 : 2661:2661:126260:126201:2661:126260:2661:126260 : 2661:2661:126260:126201 : 2661:2661:126260:2661:126260 : 2661:2661:126260:126201:126201:2661:126260:2661:126260 : 2661:2661:126260:126201:2661:126260:2661:126260 : 2661:2661:126260:126201 : 2661:2661:126260:2661:126260 : 2661:2661:126260:126201:126201 : 2661:2661:126260:2661:126260 : 2661:2661:126260:126201:2661:126260:2661:126260 : 2661:2661:126260:126201 : 2661:2661:126260:2661:126260 : 2661:2661:126260:126201:126201:126201 : 2661:2661:126260:2661:126260 : 2661:2661:126260:126201:2661:126260:2661:126260 : 2661:2661:126260:126201 : 2661:2661:126260:2661:126260 : 2661:2661:126260:126201:126201:2661:126260:2661:126260 : 2661:2661:126260:126201:2661:126260:2661:126260 : 2661:2661:126260:126201 : 2661:2661:126260:2661:126260 : 2661:2661:126260:126201:126201 : 2661:2661:126260:2661:126260 : 2661:2661:126260:126201:2661:126260:2661:126260 : 2661:2661:126260:126201 : 2661:2661:126260:2661:126260 : 2661:2661:126260:126201:126201:126201:126158", ObjectType="2661:126260:2661:126260 : 2661:2661:126260:126201:2661:126260:2661:126260 : 2661:2661:126260:126201 : 2661:2661:126260:2661:126260 : 2661:2661:126260:126201:126201:2661:126260:2661:126260 : 2661:2661:126260:126201:2661:126260:2661:126260 : 2661:2661:126260:126201 : 2661:2661:126260:2661:126260 : 2661:2661:126260:126201:126201 : 2661:2661:126260:2661:126260 : 2661:2661:126260:126201:2661:126260:2661:126260 : 2661:2661:126260:126201 : 2661:2661:126260:2661:126260 : 2661:2661:126260:126201:126201:126201 : 2661:2661:126260:2661:126260 : 2661:2661:126260:126201:2661:126260:2661:126260 : 2661:2661:126260:126201 : 2661:2661:126260:2661:126260 : 2661:2661:126260:126201:126201:2661:126260:2661:126260 : 2661:2661:126260:126201:2661:126260:2661:126260 : 2661:2661:126260:126201 : 2661:2661:126260:2661:126260 : 2661:2661:126260:126201:126201 : 2661:2661:126260:2661:126260 : 2661:2661:126260:126201:2661:126260:2661:126260 : 2661:2661:126260:126201 : 2661:2661:126260:2661:126260 : 2661:2661:126260:126201:126201:126201", OverallHeight=1600.0, OverallWidth=90.0, context=body_context, shape_type="MappedRepresentation", body=[
    mapped(shared_shape_4, transform((0.0, 0.0, 0.0), scale=1.0)),
])

save(model, "model.ifc")
